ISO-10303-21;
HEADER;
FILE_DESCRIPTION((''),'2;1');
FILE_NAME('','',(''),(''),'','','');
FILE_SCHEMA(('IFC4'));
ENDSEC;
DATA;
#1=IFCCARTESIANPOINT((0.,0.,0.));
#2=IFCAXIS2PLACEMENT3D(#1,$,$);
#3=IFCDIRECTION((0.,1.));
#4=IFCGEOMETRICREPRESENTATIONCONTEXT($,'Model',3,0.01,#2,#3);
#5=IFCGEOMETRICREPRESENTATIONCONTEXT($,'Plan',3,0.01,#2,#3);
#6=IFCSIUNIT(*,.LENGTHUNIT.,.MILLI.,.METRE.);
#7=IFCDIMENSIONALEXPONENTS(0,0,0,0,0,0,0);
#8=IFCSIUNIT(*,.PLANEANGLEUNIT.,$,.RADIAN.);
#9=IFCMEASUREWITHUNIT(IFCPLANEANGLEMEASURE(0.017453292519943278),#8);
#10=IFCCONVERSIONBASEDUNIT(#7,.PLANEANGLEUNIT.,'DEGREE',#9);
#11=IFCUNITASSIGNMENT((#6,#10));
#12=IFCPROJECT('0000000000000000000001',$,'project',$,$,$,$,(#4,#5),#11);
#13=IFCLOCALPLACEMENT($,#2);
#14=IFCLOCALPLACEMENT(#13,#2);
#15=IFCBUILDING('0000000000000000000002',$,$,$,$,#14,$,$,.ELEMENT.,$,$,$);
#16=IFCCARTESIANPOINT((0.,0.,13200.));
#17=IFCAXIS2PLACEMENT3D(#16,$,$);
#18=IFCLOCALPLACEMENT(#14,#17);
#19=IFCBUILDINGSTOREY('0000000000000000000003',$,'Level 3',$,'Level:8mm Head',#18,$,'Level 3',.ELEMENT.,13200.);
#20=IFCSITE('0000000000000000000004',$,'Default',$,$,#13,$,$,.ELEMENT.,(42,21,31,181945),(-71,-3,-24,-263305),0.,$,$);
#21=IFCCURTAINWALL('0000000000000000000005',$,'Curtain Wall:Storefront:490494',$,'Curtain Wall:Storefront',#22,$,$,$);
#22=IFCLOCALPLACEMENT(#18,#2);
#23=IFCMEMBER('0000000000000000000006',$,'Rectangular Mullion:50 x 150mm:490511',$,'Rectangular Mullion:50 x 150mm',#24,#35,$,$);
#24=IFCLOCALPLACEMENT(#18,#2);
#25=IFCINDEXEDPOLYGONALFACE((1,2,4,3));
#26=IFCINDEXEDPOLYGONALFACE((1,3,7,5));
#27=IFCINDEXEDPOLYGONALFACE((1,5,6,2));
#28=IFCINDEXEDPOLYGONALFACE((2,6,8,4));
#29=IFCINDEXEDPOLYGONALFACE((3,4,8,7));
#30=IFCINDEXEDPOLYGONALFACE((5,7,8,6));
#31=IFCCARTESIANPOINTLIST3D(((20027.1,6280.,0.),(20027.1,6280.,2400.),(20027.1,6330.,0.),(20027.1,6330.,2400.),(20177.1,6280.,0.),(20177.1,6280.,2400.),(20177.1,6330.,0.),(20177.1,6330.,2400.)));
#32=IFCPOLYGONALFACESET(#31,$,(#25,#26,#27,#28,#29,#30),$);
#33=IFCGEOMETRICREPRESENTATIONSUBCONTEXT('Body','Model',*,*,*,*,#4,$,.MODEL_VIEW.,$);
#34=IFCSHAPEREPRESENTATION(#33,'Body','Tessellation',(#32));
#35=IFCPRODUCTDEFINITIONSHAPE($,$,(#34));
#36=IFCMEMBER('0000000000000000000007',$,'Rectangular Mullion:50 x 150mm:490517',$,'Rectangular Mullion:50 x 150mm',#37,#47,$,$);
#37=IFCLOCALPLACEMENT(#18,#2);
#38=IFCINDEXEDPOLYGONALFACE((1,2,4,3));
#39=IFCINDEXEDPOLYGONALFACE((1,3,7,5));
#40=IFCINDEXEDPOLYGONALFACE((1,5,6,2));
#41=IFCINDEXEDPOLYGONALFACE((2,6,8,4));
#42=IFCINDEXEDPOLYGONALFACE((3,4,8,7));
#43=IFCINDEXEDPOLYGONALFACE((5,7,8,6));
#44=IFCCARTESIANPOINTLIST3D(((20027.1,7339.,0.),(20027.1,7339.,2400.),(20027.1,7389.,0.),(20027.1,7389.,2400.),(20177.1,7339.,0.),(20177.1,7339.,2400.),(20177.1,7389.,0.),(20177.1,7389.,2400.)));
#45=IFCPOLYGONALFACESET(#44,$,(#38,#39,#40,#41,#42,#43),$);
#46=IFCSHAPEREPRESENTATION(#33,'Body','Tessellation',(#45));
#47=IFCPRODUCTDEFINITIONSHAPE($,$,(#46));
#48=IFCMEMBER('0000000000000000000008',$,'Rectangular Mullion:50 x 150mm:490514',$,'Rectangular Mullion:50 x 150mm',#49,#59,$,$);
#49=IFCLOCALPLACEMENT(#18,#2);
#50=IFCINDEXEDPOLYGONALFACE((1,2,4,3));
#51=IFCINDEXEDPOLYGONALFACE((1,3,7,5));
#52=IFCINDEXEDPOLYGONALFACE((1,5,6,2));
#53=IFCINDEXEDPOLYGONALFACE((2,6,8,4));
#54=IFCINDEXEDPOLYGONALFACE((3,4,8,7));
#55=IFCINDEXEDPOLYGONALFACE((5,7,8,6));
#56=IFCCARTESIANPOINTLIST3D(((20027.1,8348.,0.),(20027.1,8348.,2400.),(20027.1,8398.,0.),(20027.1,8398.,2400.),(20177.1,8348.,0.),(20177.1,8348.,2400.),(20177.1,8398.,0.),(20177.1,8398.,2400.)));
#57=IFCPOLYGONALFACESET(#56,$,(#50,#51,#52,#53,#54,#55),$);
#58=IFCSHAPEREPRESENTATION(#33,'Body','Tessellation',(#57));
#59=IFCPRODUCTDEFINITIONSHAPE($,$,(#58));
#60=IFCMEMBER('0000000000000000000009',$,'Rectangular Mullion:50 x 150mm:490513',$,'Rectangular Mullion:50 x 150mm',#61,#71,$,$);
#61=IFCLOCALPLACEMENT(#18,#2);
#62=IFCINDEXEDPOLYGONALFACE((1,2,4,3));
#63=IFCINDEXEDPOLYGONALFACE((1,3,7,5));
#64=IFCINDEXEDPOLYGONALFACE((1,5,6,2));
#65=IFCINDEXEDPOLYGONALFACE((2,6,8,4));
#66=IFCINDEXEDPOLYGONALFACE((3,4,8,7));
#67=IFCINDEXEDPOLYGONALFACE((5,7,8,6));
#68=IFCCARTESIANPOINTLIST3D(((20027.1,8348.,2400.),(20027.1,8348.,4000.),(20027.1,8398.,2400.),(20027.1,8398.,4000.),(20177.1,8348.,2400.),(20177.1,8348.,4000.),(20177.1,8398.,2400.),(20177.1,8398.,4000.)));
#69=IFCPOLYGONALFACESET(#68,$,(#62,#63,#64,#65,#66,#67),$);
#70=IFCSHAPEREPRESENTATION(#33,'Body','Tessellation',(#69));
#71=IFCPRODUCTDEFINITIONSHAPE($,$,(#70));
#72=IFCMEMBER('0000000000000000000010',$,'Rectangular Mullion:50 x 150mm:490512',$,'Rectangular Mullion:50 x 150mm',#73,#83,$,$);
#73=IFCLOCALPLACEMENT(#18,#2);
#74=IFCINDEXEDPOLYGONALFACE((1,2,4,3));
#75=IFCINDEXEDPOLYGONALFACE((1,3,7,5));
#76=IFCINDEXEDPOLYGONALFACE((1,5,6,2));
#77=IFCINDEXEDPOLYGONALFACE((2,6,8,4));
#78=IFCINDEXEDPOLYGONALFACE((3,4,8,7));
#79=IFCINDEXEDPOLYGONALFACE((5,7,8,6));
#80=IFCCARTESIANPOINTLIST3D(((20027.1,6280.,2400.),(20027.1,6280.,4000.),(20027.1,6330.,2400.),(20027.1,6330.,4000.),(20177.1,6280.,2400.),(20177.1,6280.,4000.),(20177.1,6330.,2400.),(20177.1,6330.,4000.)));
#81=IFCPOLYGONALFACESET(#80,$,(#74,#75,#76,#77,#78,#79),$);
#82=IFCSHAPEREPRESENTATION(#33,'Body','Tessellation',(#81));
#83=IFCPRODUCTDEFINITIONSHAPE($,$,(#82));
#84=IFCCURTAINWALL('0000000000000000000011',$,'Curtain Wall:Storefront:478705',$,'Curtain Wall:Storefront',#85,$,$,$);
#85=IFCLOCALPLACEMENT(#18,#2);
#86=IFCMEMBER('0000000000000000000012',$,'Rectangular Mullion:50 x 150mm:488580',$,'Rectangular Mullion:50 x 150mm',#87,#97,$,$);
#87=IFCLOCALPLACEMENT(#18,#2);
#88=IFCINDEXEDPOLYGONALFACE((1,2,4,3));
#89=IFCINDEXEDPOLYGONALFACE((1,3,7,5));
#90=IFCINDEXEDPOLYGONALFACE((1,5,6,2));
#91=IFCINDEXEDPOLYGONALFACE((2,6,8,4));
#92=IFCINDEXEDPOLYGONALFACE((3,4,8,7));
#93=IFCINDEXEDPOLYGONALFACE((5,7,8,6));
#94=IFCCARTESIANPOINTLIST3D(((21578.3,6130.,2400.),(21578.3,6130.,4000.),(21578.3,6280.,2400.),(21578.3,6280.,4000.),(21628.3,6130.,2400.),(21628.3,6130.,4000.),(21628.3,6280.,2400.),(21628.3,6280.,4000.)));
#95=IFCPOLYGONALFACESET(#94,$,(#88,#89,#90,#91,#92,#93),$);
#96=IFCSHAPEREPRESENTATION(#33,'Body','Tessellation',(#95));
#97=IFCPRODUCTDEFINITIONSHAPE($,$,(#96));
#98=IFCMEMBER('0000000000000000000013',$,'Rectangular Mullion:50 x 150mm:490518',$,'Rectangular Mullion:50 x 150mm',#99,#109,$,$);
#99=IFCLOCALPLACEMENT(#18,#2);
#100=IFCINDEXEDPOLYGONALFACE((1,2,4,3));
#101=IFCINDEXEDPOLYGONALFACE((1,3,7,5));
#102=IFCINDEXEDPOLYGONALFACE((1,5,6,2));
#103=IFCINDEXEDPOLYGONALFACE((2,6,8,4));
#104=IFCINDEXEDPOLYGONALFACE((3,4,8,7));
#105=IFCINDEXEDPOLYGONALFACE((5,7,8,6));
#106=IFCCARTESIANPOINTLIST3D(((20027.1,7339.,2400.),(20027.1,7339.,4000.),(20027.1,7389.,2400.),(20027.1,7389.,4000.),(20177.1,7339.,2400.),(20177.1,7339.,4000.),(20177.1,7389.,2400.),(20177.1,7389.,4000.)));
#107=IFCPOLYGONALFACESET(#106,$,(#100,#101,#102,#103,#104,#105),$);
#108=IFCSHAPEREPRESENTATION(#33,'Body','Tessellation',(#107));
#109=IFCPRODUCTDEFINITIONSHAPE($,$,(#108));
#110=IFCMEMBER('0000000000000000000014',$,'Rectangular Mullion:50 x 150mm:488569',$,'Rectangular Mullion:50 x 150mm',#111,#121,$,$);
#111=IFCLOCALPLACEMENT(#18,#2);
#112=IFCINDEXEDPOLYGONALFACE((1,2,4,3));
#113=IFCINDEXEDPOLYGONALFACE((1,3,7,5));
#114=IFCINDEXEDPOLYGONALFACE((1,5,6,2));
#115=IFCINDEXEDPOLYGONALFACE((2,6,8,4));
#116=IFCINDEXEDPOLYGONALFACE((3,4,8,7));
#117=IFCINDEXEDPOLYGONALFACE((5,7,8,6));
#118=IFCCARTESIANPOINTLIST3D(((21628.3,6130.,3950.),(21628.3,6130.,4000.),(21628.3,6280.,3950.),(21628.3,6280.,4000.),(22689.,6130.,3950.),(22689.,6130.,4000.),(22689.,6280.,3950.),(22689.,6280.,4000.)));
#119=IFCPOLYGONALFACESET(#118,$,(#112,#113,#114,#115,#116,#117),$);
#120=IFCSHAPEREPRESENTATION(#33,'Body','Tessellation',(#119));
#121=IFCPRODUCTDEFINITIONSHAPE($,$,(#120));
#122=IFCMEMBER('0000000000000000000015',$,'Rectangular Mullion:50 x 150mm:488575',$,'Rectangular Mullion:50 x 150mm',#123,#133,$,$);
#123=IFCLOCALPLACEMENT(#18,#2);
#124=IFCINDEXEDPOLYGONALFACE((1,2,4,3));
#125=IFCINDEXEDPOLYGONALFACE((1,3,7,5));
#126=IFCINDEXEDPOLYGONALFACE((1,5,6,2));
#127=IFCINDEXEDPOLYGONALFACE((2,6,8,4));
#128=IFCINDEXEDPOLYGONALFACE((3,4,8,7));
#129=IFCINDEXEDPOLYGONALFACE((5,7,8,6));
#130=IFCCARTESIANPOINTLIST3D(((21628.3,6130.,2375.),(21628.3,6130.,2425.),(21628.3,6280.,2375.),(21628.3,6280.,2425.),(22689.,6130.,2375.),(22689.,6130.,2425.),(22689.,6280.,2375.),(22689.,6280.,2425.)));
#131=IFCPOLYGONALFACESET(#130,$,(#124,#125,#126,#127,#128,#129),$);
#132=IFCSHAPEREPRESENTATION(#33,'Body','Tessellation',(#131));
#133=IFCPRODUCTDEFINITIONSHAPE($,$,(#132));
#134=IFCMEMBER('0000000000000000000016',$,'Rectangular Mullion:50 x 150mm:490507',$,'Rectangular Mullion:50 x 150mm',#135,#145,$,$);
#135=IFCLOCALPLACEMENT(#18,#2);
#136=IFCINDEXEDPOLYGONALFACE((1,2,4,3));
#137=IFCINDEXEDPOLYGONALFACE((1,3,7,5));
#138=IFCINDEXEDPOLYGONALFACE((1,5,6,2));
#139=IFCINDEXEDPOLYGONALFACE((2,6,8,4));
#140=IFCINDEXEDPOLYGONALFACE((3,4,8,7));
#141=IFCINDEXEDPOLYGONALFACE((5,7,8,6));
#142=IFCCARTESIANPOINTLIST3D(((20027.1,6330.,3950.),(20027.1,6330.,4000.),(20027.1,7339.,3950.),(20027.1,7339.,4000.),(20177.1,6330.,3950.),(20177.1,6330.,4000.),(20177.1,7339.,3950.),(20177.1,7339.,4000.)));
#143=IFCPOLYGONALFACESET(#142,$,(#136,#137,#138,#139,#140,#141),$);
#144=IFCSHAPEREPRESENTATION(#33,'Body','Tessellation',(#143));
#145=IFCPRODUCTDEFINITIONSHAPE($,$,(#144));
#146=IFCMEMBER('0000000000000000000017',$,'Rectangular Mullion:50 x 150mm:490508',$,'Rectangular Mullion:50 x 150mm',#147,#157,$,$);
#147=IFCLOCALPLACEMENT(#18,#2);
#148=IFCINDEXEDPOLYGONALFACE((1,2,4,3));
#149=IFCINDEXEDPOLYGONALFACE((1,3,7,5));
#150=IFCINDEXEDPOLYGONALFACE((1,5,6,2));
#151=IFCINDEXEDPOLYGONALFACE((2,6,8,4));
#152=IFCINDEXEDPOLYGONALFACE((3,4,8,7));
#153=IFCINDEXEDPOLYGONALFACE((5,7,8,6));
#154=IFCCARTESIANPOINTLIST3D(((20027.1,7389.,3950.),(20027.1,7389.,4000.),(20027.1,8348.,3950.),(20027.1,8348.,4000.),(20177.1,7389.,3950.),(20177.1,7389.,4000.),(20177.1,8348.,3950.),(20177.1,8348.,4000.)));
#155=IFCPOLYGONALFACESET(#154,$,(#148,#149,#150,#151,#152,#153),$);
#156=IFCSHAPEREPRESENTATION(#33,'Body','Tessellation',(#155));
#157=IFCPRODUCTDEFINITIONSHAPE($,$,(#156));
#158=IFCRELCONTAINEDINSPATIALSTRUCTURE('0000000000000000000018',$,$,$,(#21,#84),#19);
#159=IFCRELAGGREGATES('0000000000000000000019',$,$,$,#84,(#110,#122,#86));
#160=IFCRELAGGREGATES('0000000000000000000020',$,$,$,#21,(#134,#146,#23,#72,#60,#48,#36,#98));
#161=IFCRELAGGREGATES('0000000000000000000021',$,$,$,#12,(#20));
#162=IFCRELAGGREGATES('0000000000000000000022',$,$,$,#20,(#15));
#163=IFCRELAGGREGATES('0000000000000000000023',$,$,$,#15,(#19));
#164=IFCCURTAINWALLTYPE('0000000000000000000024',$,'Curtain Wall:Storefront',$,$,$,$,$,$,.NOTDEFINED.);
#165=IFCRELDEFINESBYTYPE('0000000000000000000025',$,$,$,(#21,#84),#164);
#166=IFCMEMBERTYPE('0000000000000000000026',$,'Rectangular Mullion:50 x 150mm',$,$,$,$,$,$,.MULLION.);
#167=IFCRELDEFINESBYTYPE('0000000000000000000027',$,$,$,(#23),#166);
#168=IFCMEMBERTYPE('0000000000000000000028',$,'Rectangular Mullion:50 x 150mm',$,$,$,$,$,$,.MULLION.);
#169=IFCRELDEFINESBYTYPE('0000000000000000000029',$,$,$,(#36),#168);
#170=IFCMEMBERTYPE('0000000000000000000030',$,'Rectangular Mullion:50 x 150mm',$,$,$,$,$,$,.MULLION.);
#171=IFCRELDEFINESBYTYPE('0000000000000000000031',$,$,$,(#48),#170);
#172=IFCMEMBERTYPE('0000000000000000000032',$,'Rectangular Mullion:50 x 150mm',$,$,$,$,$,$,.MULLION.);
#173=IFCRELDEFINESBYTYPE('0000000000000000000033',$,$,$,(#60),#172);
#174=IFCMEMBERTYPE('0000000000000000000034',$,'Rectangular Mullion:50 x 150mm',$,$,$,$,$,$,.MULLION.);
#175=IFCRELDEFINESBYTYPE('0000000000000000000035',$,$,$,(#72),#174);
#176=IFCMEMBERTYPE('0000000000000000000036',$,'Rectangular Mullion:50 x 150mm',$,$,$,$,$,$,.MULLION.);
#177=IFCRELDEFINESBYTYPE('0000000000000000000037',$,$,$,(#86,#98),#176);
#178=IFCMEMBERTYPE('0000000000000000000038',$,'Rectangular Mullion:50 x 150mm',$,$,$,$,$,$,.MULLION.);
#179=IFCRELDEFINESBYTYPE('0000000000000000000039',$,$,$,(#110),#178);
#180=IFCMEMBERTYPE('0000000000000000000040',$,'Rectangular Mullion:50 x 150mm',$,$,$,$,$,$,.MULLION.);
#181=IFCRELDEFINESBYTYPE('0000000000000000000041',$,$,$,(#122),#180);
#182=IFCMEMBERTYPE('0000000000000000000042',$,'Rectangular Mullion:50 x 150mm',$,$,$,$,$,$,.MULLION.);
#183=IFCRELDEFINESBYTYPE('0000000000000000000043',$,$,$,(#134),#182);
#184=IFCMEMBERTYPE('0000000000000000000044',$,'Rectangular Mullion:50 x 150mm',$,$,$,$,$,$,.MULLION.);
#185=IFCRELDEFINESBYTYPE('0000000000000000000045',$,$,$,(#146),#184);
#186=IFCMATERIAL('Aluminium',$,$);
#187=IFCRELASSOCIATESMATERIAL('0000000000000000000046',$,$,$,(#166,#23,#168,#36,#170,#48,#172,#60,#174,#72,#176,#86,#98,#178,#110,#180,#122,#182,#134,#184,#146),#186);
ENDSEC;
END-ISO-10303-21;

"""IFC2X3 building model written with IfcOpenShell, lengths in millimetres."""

from ifc_helpers import new_model, entity, si_unit, converted_unit, direction, frame, origin, origin_2d_with_axis, place, context, subcontext, project, spatial, rectangle, extrude, source, transform, mapped, material, type_object, type_shapes, element, aggregate, save


model = new_model("IFC2X3")

# Units and contexts
model_context = context("Model", 3, precision=0.01, world=origin(), true_north=direction((0.0, 1.0)))
plan_context = context("Plan", 3, precision=0.01, world=origin(), true_north=direction((0.0, 1.0)))
body_context = subcontext(model_context, "Body", "Model", "MODEL_VIEW")
ifc_project = project(units=[si_unit("LENGTHUNIT", "METRE", prefix="MILLI"), converted_unit("PLANEANGLEUNIT", "DEGREE", entity("IfcPlaneAngleMeasure", 0.017453292519943278), si_unit("PLANEANGLEUNIT", "RADIAN"), dimensions=[0, 0, 0, 0, 0, 0, 0])], contexts=[model_context, plan_context])

# Site, building, storey
site_placement = place(None, origin())
site = spatial("IfcSite", under=ifc_project, at=site_placement, Name="Default", CompositionType="ELEMENT", RefLatitude=(42, 21, 31, 181945), RefLongitude=(-71, -3, -24, -263305), RefElevation=0.0)
building_placement = place(site_placement, origin())
building = spatial("IfcBuilding", under=site, at=building_placement, CompositionType="ELEMENT")
storey_placement = place(building_placement, frame((0.0, 0.0, 13200.0)))
storey = spatial("IfcBuildingStorey", under=building, at=storey_placement, Name="Level 3", ObjectType="Level:8mm Head", LongName="Level 3", CompositionType="ELEMENT", Elevation=13200.0)

# Curtain wall, members
curtain_wall_type = type_object("IfcCurtainWallType", Name="Curtain Wall:Storefront", PredefinedType="NOTDEFINED")
curtain_wall_1_placement = place(storey_placement, frame((0.0, 0.0, -13200.0)))
curtain_wall_1 = element("IfcCurtainWall", 1, at=curtain_wall_1_placement, inside=storey, type_object=curtain_wall_type, Name="Curtain Wall:Storefront:490494", ObjectType="Curtain Wall:Storefront")
ifc_material_1 = material(Name="Aluminium")
member_type_1 = type_object("IfcMemberType", Name="Rectangular Mullion:50 x 150mm", PredefinedType="MULLION", material=ifc_material_1)
shared_shape_1 = source(origin(), body_context, "Body", "SweptSolid", [
    extrude(rectangle(XDim=50.0, YDim=150.0, at=origin_2d_with_axis()), frame((-25.0, 0.0, -2400.0), z_axis=(0.0, 0.0, 1.0), x_axis=(-1.0, 0.0, 0.0)), (0.0, 0.0, 1.0), 2400.0),
])
type_shapes(member_type_1, [shared_shape_1])
member_1_placement = place(curtain_wall_1_placement, frame((20102.1, 6280.0, 13200.0), z_axis=(0.0, 0.0, -1.0), x_axis=(0.0, -1.0, 0.0)))
member_1 = element("IfcMember", 2, at=member_1_placement, type_object=member_type_1, material=ifc_material_1, Name="Rectangular Mullion:50 x 150mm:490511", ObjectType="Rectangular Mullion:50 x 150mm", context=body_context, shape_type="MappedRepresentation", body=[
    mapped(shared_shape_1, transform((0.0, 0.0, 0.0), scale=1.0)),
])
member_type_2 = type_object("IfcMemberType", Name="Rectangular Mullion:50 x 150mm", PredefinedType="MULLION", material=ifc_material_1)
shared_shape_2 = source(origin(), body_context, "Body", "SweptSolid", [
    extrude(rectangle(XDim=50.0, YDim=150.0, at=origin_2d_with_axis()), frame((0.0, 0.0, -2400.0), z_axis=(0.0, 0.0, 1.0), x_axis=(-1.0, 0.0, 0.0)), (0.0, 0.0, 1.0), 2400.0),
])
type_shapes(member_type_2, [shared_shape_2])
member_2_placement = place(curtain_wall_1_placement, frame((20102.1, 7364.0, 13200.0), z_axis=(0.0, 0.0, -1.0), x_axis=(0.0, -1.0, 0.0)))
member_2 = element("IfcMember", 3, at=member_2_placement, type_object=member_type_2, material=ifc_material_1, Name="Rectangular Mullion:50 x 150mm:490517", ObjectType="Rectangular Mullion:50 x 150mm", context=body_context, shape_type="MappedRepresentation", body=[
    mapped(shared_shape_2, transform((0.0, 0.0, 0.0), scale=1.0)),
])
member_type_3 = type_object("IfcMemberType", Name="Rectangular Mullion:50 x 150mm", PredefinedType="MULLION", material=ifc_material_1)
shared_shape_3 = source(origin(), body_context, "Body", "SweptSolid", [
    extrude(rectangle(XDim=50.0, YDim=150.0, at=origin_2d_with_axis()), frame((-25.0, 0.0, -2400.0), z_axis=(0.0, 0.0, 1.0), x_axis=(-1.0, 0.0, 0.0)), (0.0, 0.0, 1.0), 2400.0),
])
type_shapes(member_type_3, [shared_shape_3])
member_3_placement = place(curtain_wall_1_placement, frame((20102.1, 8398.0, 15600.0), z_axis=(0.0, 0.0, 1.0), x_axis=(0.0, 1.0, 0.0)))
member_3 = element("IfcMember", 4, at=member_3_placement, type_object=member_type_3, material=ifc_material_1, Name="Rectangular Mullion:50 x 150mm:490514", ObjectType="Rectangular Mullion:50 x 150mm", context=body_context, shape_type="MappedRepresentation", body=[
    mapped(shared_shape_3, transform((0.0, 0.0, 0.0), scale=1.0)),
])
member_type_4 = type_object("IfcMemberType", Name="Rectangular Mullion:50 x 150mm", PredefinedType="MULLION", material=ifc_material_1)
shared_shape_4 = source(origin(), body_context, "Body", "SweptSolid", [
    extrude(rectangle(XDim=50.0, YDim=150.0, at=origin_2d_with_axis()), frame((-25.0, 0.0, -1600.0), z_axis=(0.0, 0.0, 1.0), x_axis=(-1.0, 0.0, 0.0)), (0.0, 0.0, 1.0), 1600.0),
])
type_shapes(member_type_4, [shared_shape_4])
member_4_placement = place(curtain_wall_1_placement, frame((20102.1, 8398.0, 17200.0), z_axis=(0.0, 0.0, 1.0), x_axis=(0.0, 1.0, 0.0)))
member_4 = element("IfcMember", 5, at=member_4_placement, type_object=member_type_4, material=ifc_material_1, Name="Rectangular Mullion:50 x 150mm:490513", ObjectType="Rectangular Mullion:50 x 150mm", context=body_context, shape_type="MappedRepresentation", body=[
    mapped(shared_shape_4, transform((0.0, 0.0, 0.0), scale=1.0)),
])
member_type_5 = type_object("IfcMemberType", Name="Rectangular Mullion:50 x 150mm", PredefinedType="MULLION", material=ifc_material_1)
shared_shape_5 = source(origin(), body_context, "Body", "SweptSolid", [
    extrude(rectangle(XDim=50.0, YDim=150.0, at=origin_2d_with_axis()), frame((-25.0, 0.0, -1600.0), z_axis=(0.0, 0.0, 1.0), x_axis=(-1.0, 0.0, 0.0)), (0.0, 0.0, 1.0), 1600.0),
])
type_shapes(member_type_5, [shared_shape_5])
member_5_placement = place(curtain_wall_1_placement, frame((20102.1, 6280.0, 15600.0), z_axis=(0.0, 0.0, -1.0), x_axis=(0.0, -1.0, 0.0)))
member_5 = element("IfcMember", 6, at=member_5_placement, type_object=member_type_5, material=ifc_material_1, Name="Rectangular Mullion:50 x 150mm:490512", ObjectType="Rectangular Mullion:50 x 150mm", context=body_context, shape_type="MappedRepresentation", body=[
    mapped(shared_shape_5, transform((0.0, 0.0, 0.0), scale=1.0)),
])

# Curtain wall, member
curtain_wall_2_placement = place(storey_placement, frame((0.0, 0.0, -13200.0)))
curtain_wall_2 = element("IfcCurtainWall", 7, at=curtain_wall_2_placement, inside=storey, type_object=curtain_wall_type, Name="Curtain Wall:Storefront:478705", ObjectType="Curtain Wall:Storefront")
member_type_6 = type_object("IfcMemberType", Name="Rectangular Mullion:50 x 150mm", PredefinedType="MULLION", material=ifc_material_1)
shared_shape_6 = source(origin(), body_context, "Body", "SweptSolid", [
    extrude(rectangle(XDim=50.0, YDim=150.0, at=origin_2d_with_axis()), frame((0.0, 0.0, -1600.0), z_axis=(0.0, 0.0, 1.0), x_axis=(-1.0, 0.0, 0.0)), (0.0, 0.0, 1.0), 1600.0),
])
type_shapes(member_type_6, [shared_shape_6])
member_6_placement = place(curtain_wall_2_placement, frame((21603.3, 6205.0, 15600.0), z_axis=(0.0, 0.0, -1.0), x_axis=(-1.0, 0.0, 0.0)))
member_6 = element("IfcMember", 8, at=member_6_placement, type_object=member_type_6, material=ifc_material_1, Name="Rectangular Mullion:50 x 150mm:488580", ObjectType="Rectangular Mullion:50 x 150mm", context=body_context, shape_type="MappedRepresentation", body=[
    mapped(shared_shape_6, transform((0.0, 0.0, 0.0), scale=1.0)),
])

# Members
member_7_placement = place(curtain_wall_1_placement, frame((20102.1, 7364.0, 15600.0), z_axis=(0.0, 0.0, -1.0), x_axis=(0.0, -1.0, 0.0)))
member_7 = element("IfcMember", 9, at=member_7_placement, type_object=member_type_6, material=ifc_material_1, Name="Rectangular Mullion:50 x 150mm:490518", ObjectType="Rectangular Mullion:50 x 150mm", context=body_context, shape_type="MappedRepresentation", body=[
    mapped(shared_shape_6, transform((0.0, 0.0, 0.0), scale=1.0)),
])
member_type_7 = type_object("IfcMemberType", Name="Rectangular Mullion:50 x 150mm", PredefinedType="MULLION", material=ifc_material_1)
shared_shape_7 = source(origin(), body_context, "Body", "SweptSolid", [
    extrude(rectangle(XDim=50.0, YDim=150.0, at=origin_2d_with_axis()), frame((-25.0, 0.0, -1060.7), z_axis=(0.0, 0.0, 1.0), x_axis=(-1.0, 0.0, 0.0)), (0.0, 0.0, 1.0), 1060.7),
])
type_shapes(member_type_7, [shared_shape_7])
member_8_placement = place(curtain_wall_2_placement, frame((21628.3, 6205.0, 17200.0), z_axis=(-1.0, 0.0, 0.0), x_axis=(0.0, 0.0, 1.0)))
member_8 = element("IfcMember", 10, at=member_8_placement, type_object=member_type_7, material=ifc_material_1, Name="Rectangular Mullion:50 x 150mm:488569", ObjectType="Rectangular Mullion:50 x 150mm", context=body_context, shape_type="MappedRepresentation", body=[
    mapped(shared_shape_7, transform((0.0, 0.0, 0.0), scale=1.0)),
])
member_type_8 = type_object("IfcMemberType", Name="Rectangular Mullion:50 x 150mm", PredefinedType="MULLION", material=ifc_material_1)
shared_shape_8 = source(origin(), body_context, "Body", "SweptSolid", [
    extrude(rectangle(XDim=50.0, YDim=150.0, at=origin_2d_with_axis()), frame((0.0, 0.0, -1060.7), z_axis=(0.0, 0.0, 1.0), x_axis=(-1.0, 0.0, 0.0)), (0.0, 0.0, 1.0), 1060.7),
])
type_shapes(member_type_8, [shared_shape_8])
member_9_placement = place(curtain_wall_2_placement, frame((21628.3, 6205.0, 15600.0), z_axis=(-1.0, 0.0, 0.0), x_axis=(0.0, 0.0, 1.0)))
member_9 = element("IfcMember", 11, at=member_9_placement, type_object=member_type_8, material=ifc_material_1, Name="Rectangular Mullion:50 x 150mm:488575", ObjectType="Rectangular Mullion:50 x 150mm", context=body_context, shape_type="MappedRepresentation", body=[
    mapped(shared_shape_8, transform((0.0, 0.0, 0.0), scale=1.0)),
])
member_type_9 = type_object("IfcMemberType", Name="Rectangular Mullion:50 x 150mm", PredefinedType="MULLION", material=ifc_material_1)
shared_shape_9 = source(origin(), body_context, "Body", "SweptSolid", [
    extrude(rectangle(XDim=50.0, YDim=150.0, at=origin_2d_with_axis()), frame((-25.0, 0.0, -1009.0), z_axis=(0.0, 0.0, 1.0), x_axis=(-1.0, 0.0, 0.0)), (0.0, 0.0, 1.0), 1009.0),
])
type_shapes(member_type_9, [shared_shape_9])
member_10_placement = place(curtain_wall_1_placement, frame((20102.1, 6330.0, 17200.0), z_axis=(0.0, -1.0, 0.0), x_axis=(0.0, 0.0, 1.0)))
member_10 = element("IfcMember", 12, at=member_10_placement, type_object=member_type_9, material=ifc_material_1, Name="Rectangular Mullion:50 x 150mm:490507", ObjectType="Rectangular Mullion:50 x 150mm", context=body_context, shape_type="MappedRepresentation", body=[
    mapped(shared_shape_9, transform((0.0, 0.0, 0.0), scale=1.0)),
])
member_type_10 = type_object("IfcMemberType", Name="Rectangular Mullion:50 x 150mm", PredefinedType="MULLION", material=ifc_material_1)
shared_shape_10 = source(origin(), body_context, "Body", "SweptSolid", [
    extrude(rectangle(XDim=50.0, YDim=150.0, at=origin_2d_with_axis()), frame((-25.0, 0.0, -959.0), z_axis=(0.0, 0.0, 1.0), x_axis=(-1.0, 0.0, 0.0)), (0.0, 0.0, 1.0), 959.0),
])
type_shapes(member_type_10, [shared_shape_10])
member_11_placement = place(curtain_wall_1_placement, frame((20102.1, 7389.0, 17200.0), z_axis=(0.0, -1.0, 0.0), x_axis=(0.0, 0.0, 1.0)))
member_11 = element("IfcMember", 13, at=member_11_placement, type_object=member_type_10, material=ifc_material_1, Name="Rectangular Mullion:50 x 150mm:490508", ObjectType="Rectangular Mullion:50 x 150mm", context=body_context, shape_type="MappedRepresentation", body=[
    mapped(shared_shape_10, transform((0.0, 0.0, 0.0), scale=1.0)),
])

aggregate(curtain_wall_2, [member_8, member_9, member_6])

aggregate(curtain_wall_1, [member_10, member_11, member_1, member_5, member_4, member_3, member_2, member_7])

save(model, "model.ifc")
